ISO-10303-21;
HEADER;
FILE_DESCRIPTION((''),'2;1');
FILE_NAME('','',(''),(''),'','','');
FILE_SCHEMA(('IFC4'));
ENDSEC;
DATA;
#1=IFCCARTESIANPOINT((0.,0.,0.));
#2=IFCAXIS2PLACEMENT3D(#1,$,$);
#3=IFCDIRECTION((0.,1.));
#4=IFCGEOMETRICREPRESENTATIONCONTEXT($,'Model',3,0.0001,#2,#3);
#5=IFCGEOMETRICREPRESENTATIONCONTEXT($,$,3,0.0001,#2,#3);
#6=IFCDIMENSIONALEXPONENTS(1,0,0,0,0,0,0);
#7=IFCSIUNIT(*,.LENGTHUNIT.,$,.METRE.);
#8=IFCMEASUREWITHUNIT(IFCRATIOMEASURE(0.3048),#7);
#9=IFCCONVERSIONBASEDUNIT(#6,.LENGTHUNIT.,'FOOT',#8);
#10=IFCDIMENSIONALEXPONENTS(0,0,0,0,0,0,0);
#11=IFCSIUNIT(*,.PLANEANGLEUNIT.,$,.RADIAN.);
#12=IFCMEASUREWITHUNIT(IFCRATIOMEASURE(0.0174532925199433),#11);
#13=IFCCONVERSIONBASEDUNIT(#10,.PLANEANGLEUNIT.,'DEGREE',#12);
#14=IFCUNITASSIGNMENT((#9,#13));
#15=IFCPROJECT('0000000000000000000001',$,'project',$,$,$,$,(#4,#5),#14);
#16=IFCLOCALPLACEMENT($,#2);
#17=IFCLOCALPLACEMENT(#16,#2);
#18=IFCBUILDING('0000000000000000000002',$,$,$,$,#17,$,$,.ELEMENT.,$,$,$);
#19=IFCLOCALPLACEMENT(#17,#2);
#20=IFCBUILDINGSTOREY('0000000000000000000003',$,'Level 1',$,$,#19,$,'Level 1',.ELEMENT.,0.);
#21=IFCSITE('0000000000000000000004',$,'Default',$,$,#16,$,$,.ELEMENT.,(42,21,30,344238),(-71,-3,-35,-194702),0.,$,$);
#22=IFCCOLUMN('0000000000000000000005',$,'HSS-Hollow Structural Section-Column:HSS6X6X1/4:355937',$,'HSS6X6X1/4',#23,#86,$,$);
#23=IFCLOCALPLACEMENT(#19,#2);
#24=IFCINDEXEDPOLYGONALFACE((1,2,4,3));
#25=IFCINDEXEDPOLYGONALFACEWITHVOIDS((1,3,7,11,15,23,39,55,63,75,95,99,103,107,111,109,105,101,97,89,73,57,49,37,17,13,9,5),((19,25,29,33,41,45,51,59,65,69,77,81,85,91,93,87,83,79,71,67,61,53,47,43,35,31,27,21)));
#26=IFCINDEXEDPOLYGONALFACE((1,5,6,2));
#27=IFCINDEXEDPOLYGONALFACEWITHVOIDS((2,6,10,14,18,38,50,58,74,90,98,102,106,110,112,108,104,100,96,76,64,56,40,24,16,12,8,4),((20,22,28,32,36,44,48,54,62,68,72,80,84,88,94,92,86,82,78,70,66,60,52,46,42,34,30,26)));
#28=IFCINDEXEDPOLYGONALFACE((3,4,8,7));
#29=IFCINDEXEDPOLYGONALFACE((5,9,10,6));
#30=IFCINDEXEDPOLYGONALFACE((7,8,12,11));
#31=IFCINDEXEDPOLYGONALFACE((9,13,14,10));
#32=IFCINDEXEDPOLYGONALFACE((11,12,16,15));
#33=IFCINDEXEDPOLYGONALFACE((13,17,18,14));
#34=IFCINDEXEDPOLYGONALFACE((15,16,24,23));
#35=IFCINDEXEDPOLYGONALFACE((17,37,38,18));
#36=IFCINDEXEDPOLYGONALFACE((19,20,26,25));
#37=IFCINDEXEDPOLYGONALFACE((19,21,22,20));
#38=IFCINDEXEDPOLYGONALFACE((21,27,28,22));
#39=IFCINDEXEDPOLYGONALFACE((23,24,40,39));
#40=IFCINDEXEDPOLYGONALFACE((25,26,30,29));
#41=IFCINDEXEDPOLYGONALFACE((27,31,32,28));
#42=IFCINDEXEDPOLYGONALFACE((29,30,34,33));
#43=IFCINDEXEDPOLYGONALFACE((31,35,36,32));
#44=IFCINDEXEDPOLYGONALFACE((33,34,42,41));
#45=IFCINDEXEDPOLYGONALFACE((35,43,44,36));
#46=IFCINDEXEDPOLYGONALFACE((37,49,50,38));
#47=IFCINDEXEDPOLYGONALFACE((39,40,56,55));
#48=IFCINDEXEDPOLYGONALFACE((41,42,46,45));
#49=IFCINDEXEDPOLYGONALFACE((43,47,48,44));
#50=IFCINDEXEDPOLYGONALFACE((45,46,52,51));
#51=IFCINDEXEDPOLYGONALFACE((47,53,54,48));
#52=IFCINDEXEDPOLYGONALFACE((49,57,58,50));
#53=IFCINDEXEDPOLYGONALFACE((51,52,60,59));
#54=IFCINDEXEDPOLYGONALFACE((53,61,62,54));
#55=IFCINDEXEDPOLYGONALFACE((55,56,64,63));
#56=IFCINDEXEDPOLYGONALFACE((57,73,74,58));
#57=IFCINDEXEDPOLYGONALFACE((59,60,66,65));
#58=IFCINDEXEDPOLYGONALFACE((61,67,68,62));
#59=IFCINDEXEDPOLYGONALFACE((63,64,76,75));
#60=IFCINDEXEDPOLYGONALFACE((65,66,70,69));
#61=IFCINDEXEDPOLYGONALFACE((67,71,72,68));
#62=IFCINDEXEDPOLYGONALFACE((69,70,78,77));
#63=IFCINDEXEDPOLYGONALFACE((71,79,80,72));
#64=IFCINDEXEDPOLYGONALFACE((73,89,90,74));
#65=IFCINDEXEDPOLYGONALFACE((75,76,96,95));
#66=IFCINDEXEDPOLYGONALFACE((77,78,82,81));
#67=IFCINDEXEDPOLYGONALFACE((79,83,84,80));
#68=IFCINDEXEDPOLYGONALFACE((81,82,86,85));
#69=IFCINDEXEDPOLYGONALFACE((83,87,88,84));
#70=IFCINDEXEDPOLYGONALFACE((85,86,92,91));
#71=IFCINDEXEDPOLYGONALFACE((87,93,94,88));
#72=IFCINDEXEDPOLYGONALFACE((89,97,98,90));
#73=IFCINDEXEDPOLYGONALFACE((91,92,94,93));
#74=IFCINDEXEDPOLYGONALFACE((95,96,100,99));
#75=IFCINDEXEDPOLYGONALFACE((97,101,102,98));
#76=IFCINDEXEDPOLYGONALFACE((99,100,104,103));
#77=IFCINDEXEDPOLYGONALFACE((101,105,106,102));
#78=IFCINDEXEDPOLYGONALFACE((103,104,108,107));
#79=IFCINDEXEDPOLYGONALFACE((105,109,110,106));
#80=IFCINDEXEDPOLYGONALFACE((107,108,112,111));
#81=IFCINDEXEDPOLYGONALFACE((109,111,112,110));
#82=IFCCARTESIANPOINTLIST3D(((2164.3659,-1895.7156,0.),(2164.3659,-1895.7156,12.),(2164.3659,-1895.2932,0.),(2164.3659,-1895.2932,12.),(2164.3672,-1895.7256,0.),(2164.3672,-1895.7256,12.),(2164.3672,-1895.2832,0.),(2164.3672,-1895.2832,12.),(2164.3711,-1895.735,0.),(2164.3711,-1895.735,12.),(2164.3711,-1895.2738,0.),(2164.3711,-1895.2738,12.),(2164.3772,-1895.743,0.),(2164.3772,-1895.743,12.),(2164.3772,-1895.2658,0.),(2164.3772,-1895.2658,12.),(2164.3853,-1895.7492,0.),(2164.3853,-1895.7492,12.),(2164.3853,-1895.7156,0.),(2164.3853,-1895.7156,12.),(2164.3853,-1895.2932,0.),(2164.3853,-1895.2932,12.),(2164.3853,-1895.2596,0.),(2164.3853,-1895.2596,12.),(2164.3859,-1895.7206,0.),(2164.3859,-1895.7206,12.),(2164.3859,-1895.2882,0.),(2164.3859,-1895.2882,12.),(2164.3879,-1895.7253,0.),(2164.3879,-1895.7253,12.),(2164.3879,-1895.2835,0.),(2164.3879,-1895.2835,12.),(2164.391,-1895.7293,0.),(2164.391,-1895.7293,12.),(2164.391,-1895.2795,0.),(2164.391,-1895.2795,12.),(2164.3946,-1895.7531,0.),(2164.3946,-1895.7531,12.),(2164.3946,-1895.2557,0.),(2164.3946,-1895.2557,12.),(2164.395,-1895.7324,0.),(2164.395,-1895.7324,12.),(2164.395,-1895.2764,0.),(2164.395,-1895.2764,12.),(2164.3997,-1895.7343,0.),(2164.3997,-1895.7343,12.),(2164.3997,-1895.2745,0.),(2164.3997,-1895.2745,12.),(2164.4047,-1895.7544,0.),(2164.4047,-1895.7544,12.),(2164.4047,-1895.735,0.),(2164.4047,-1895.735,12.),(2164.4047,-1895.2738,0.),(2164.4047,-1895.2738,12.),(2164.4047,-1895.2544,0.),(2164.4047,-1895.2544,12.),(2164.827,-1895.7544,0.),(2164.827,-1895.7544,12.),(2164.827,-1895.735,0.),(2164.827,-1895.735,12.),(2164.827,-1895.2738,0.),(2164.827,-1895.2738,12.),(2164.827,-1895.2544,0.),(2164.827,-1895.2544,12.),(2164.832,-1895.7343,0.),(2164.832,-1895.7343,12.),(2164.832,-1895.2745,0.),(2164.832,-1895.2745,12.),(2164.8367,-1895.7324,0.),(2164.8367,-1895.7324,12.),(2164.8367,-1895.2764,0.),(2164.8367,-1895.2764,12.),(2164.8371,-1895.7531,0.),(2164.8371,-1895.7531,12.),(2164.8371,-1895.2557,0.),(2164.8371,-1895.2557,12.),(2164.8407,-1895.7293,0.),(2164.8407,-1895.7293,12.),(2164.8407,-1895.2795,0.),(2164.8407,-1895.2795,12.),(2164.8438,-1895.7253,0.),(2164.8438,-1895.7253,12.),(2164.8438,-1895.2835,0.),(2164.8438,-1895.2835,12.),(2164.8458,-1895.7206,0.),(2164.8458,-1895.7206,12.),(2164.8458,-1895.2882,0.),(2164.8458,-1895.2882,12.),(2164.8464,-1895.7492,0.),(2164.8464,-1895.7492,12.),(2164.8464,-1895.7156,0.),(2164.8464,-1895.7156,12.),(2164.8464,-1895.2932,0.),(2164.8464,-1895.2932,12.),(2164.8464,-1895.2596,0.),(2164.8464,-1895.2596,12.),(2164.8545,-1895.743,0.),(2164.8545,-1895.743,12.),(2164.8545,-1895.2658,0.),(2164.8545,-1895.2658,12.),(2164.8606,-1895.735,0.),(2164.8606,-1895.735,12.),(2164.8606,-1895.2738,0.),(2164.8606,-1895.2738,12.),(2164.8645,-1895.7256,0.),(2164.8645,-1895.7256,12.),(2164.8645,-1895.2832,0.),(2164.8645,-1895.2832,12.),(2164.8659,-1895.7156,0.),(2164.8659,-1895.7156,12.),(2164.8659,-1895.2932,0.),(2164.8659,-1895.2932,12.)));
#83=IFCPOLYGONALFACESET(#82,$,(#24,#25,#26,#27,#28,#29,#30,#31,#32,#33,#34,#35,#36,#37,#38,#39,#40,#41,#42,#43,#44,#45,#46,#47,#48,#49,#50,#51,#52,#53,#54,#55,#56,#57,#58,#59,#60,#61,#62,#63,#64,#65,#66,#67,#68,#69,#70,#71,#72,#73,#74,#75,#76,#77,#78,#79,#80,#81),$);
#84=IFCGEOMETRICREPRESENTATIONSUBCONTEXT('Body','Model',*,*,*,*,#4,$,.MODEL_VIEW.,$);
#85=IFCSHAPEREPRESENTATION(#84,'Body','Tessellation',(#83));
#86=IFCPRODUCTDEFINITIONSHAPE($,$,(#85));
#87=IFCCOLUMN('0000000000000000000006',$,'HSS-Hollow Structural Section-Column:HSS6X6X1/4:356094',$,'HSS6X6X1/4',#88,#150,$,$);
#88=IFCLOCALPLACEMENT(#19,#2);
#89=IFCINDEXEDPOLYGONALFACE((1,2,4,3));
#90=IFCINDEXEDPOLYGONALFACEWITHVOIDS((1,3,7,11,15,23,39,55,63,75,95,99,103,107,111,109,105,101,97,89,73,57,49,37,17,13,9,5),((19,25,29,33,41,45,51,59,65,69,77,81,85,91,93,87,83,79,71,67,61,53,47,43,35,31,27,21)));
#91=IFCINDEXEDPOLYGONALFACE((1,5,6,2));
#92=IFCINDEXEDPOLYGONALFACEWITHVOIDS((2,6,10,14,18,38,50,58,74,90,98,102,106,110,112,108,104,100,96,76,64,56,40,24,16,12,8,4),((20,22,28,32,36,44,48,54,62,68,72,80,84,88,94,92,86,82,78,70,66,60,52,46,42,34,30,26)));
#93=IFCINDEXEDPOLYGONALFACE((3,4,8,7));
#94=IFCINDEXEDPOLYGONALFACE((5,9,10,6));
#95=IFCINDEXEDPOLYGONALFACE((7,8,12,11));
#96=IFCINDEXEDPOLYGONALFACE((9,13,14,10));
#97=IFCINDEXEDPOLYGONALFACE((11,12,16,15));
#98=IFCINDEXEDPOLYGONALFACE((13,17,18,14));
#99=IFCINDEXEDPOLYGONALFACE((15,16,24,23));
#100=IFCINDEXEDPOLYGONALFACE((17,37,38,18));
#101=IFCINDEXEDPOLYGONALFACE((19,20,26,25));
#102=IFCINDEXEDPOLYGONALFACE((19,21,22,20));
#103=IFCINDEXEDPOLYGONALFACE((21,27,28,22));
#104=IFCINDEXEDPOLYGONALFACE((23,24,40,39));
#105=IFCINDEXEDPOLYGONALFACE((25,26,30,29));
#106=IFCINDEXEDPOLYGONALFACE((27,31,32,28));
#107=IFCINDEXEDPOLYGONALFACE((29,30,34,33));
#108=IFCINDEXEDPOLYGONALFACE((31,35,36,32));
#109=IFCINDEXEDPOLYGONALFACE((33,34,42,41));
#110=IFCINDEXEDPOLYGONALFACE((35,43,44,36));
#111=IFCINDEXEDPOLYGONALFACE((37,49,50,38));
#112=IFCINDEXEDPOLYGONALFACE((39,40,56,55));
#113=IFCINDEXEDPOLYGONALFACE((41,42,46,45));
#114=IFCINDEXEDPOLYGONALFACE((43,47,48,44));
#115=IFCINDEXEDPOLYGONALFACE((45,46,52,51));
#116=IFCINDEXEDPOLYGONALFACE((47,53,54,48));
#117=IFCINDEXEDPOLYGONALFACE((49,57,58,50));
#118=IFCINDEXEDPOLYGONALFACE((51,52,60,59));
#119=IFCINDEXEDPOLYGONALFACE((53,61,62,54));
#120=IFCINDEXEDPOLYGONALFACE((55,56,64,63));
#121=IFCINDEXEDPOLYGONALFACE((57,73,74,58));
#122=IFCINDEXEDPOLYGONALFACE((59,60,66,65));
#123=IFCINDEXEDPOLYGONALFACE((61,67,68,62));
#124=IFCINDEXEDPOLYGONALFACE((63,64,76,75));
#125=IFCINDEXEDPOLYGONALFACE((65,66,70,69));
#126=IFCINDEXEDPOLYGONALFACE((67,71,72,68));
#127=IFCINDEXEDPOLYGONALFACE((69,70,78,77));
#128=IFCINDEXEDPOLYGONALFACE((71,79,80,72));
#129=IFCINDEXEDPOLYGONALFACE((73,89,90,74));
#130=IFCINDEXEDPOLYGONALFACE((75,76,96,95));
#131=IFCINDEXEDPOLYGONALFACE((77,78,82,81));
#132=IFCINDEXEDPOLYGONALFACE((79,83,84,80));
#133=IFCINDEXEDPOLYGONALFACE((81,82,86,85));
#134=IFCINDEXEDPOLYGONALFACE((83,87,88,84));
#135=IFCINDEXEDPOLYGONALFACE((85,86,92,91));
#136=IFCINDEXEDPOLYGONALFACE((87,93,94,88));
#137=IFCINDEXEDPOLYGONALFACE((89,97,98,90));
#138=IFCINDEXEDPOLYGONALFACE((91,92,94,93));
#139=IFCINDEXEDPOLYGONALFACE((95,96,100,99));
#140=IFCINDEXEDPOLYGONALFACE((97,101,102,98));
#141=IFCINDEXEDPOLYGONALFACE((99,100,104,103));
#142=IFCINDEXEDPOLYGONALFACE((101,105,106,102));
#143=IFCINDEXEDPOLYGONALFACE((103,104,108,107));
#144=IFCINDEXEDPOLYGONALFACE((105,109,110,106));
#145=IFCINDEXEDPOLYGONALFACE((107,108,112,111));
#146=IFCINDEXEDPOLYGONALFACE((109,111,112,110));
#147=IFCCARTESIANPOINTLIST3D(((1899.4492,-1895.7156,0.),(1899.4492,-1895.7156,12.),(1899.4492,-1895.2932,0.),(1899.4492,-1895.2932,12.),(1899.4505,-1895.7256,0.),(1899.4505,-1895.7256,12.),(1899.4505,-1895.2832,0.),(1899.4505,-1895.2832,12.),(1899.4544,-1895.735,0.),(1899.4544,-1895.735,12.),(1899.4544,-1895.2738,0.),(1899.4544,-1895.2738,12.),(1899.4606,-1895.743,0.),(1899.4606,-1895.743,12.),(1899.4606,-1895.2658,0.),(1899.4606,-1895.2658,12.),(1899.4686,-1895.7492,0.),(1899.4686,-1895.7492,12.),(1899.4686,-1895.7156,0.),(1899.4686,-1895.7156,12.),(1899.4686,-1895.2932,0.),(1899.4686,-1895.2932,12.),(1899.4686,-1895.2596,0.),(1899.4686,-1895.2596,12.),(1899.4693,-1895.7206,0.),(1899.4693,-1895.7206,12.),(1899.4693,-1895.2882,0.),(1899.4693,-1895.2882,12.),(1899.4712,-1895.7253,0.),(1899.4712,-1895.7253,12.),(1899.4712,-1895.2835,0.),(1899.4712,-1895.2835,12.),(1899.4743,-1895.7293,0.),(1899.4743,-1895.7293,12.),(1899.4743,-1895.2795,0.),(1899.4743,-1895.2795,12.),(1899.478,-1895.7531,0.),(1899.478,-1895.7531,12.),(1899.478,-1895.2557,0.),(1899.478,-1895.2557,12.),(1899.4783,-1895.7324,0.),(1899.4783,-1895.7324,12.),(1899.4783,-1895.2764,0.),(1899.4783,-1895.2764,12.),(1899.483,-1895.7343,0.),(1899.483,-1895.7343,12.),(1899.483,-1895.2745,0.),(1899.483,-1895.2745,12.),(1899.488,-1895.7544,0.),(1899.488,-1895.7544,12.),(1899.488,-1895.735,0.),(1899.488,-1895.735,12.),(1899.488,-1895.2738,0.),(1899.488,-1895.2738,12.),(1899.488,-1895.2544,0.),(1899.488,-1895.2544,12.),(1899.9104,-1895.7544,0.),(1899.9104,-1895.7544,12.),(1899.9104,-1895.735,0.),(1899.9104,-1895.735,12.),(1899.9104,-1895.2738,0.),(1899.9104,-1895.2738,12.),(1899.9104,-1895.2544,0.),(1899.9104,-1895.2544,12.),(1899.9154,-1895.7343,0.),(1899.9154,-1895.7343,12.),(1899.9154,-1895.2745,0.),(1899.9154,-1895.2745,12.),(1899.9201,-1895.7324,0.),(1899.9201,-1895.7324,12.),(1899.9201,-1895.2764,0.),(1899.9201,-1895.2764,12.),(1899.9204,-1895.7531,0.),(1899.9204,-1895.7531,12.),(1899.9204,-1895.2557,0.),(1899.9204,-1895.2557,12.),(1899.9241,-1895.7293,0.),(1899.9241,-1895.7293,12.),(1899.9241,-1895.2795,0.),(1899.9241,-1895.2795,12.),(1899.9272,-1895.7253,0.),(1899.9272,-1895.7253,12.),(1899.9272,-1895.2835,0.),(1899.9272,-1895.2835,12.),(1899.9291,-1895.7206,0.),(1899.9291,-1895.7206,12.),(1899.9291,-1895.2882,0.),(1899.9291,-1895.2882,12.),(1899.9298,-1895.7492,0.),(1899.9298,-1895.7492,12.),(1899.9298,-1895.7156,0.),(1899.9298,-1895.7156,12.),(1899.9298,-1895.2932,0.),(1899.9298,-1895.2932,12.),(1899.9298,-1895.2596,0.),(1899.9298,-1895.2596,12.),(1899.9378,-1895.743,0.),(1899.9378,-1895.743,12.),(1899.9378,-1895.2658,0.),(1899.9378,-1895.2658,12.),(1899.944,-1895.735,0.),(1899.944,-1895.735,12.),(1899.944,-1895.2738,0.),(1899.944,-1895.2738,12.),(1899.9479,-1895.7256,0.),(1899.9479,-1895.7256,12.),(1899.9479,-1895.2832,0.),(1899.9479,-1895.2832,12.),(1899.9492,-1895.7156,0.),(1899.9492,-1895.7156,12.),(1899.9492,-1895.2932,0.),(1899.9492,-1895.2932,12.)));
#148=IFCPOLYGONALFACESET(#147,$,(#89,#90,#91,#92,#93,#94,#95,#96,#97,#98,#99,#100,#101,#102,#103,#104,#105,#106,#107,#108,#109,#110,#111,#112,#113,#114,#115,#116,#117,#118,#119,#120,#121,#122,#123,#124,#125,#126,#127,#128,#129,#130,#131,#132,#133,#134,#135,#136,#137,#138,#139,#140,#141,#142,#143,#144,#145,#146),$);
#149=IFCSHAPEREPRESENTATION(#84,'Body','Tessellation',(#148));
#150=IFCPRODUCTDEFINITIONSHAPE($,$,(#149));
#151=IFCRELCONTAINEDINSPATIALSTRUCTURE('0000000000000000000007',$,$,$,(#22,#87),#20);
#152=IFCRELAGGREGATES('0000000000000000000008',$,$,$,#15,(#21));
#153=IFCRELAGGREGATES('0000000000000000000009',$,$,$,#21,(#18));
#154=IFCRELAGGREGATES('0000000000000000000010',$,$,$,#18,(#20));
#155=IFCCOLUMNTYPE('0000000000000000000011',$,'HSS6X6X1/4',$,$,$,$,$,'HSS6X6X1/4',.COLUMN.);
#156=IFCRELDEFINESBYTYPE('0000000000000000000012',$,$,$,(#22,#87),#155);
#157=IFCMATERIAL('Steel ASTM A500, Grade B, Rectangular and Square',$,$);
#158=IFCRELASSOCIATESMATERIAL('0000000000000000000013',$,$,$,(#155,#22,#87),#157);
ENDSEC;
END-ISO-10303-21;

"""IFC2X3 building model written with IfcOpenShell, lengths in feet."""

from ifc_helpers import new_model, entity, si_unit, converted_unit, direction, frame, frame_2d, origin, place, context, subcontext, project, spatial, polyline, circle_curve, parameter, trimmed, segment, composite_curve, outline, extrude, source, transform, mapped, material, type_object, type_shapes, element, save


model = new_model("IFC2X3")

# Units and contexts
model_context = context("Model", 3, precision=0.0001, world=origin(), true_north=direction((0.0, 1.0)))
context_of_model = context(None, 3, precision=0.0001, world=origin(), true_north=direction((0.0, 1.0)))
body_context = subcontext(model_context, "Body", "Model", "MODEL_VIEW")
ifc_project = project(units=[converted_unit("LENGTHUNIT", "FOOT", entity("IfcRatioMeasure", 0.3048), si_unit("LENGTHUNIT", "METRE"), dimensions=[1, 0, 0, 0, 0, 0, 0]), converted_unit("PLANEANGLEUNIT", "DEGREE", entity("IfcRatioMeasure", 0.0174532925199433), si_unit("PLANEANGLEUNIT", "RADIAN"), dimensions=[0, 0, 0, 0, 0, 0, 0])], contexts=[model_context, context_of_model])

# Site, building, storey
site_placement = place(None, origin())
site = spatial("IfcSite", under=ifc_project, at=site_placement, Name="Default", CompositionType="ELEMENT", RefLatitude=(42, 21, 30, 344238), RefLongitude=(-71, -3, -35, -194702), RefElevation=0.0)
building_placement = place(site_placement, origin())
building = spatial("IfcBuilding", under=site, at=building_placement, CompositionType="ELEMENT")
storey_placement = place(building_placement, origin())
storey = spatial("IfcBuildingStorey", under=building, at=storey_placement, Name="Level 1", LongName="Level 1", CompositionType="ELEMENT", Elevation=0.0)

# Columns
ifc_material_1 = material(Name="Steel ASTM A500, Grade B, Rectangular and Square")
column_type = type_object("IfcColumnType", Name="HSS6X6X1/4", ElementType="HSS6X6X1/4", PredefinedType="COLUMN", material=ifc_material_1)
shared_shape = source(origin(), body_context, "Body", "SweptSolid", [
    extrude(outline(composite_curve([segment(polyline([(-0.2112, -0.25), (0.2112, -0.25)]), True, "CONTINUOUS"), segment(trimmed(circle_curve(frame_2d((0.2112, -0.2112), x_axis=(-1.0, 0.0)), 0.0388), [parameter(90.0)], [parameter(180.0)], True, "PARAMETER"), True, "CONTINUOUS"), segment(polyline([(0.25, -0.2112), (0.25, 0.2112)]), True, "CONTINUOUS"), segment(trimmed(circle_curve(frame_2d((0.2112, 0.2112), x_axis=(-1.0, 0.0)), 0.0388), [parameter(180.0)], [parameter(270.0)], True, "PARAMETER"), True, "CONTINUOUS"), segment(polyline([(0.2112, 0.25), (-0.2112, 0.25)]), True, "CONTINUOUS"), segment(trimmed(circle_curve(frame_2d((-0.2112, 0.2112), x_axis=(-1.0, 0.0)), 0.0388), [parameter(270.0)], [parameter(360.0)], True, "PARAMETER"), True, "CONTINUOUS"), segment(polyline([(-0.25, 0.2112), (-0.25, -0.2112)]), True, "CONTINUOUS"), segment(trimmed(circle_curve(frame_2d((-0.2112, -0.2112), x_axis=(-1.0, 0.0)), 0.0388), [parameter(360.0)], [parameter(90.0)], True, "PARAMETER"), True, "CONTINUOUS")], self_intersect=False), holes=[composite_curve([segment(trimmed(circle_curve(frame_2d((-0.2112, -0.2112), x_axis=(-1.0, 0.0)), 0.0194), [parameter(0.0)], [parameter(90.0)], True, "PARAMETER"), False, "CONTINUOUS"), segment(polyline([(-0.2306, -0.2112), (-0.2306, 0.2112)]), True, "CONTINUOUS"), segment(trimmed(circle_curve(frame_2d((-0.2112, 0.2112), x_axis=(-1.0, 0.0)), 0.0194), [parameter(270.0)], [parameter(360.0)], True, "PARAMETER"), False, "CONTINUOUS"), segment(polyline([(-0.2112, 0.2306), (0.2112, 0.2306)]), True, "CONTINUOUS"), segment(trimmed(circle_curve(frame_2d((0.2112, 0.2112), x_axis=(-1.0, 0.0)), 0.0194), [parameter(180.0)], [parameter(270.0)], True, "PARAMETER"), False, "CONTINUOUS"), segment(polyline([(0.2306, 0.2112), (0.2306, -0.2112)]), True, "CONTINUOUS"), segment(trimmed(circle_curve(frame_2d((0.2112, -0.2112), x_axis=(-1.0, 0.0)), 0.0194), [parameter(90.0)], [parameter(180.0)], True, "PARAMETER"), False, "CONTINUOUS"), segment(polyline([(0.2112, -0.2306), (-0.2112, -0.2306)]), True, "CONTINUOUS")], self_intersect=False)]), frame((0.0, 0.0, 0.0), z_axis=(0.0, 0.0, 1.0), x_axis=(-1.0, 0.0, 0.0)), (0.0, 0.0, 1.0), 12.0),
])
type_shapes(column_type, [shared_shape])
for number, where, z_axis, x_axis, name in (
    (1, (2164.6159, -1895.5044, 0.0), (0.0, 0.0, 1.0), (-1.0, 0.0, 0.0), "HSS-Hollow Structural Section-Column:HSS6X6X1/4:355937"),
    (2, (1899.6992, -1895.5044, 0.0), (0.0, 0.0, 1.0), (-1.0, 0.0, 0.0), "HSS-Hollow Structural Section-Column:HSS6X6X1/4:356094"),
):
    element("IfcColumn", number, at=place(storey_placement, frame(where, z_axis=z_axis, x_axis=x_axis)), inside=storey, type_object=column_type, material=ifc_material_1, Name=name, ObjectType="HSS6X6X1/4", context=body_context, shape_type="MappedRepresentation", body=[
        mapped(shared_shape, transform((0.0, 0.0, 0.0), scale=1.0)),
    ])

save(model, "model.ifc")
